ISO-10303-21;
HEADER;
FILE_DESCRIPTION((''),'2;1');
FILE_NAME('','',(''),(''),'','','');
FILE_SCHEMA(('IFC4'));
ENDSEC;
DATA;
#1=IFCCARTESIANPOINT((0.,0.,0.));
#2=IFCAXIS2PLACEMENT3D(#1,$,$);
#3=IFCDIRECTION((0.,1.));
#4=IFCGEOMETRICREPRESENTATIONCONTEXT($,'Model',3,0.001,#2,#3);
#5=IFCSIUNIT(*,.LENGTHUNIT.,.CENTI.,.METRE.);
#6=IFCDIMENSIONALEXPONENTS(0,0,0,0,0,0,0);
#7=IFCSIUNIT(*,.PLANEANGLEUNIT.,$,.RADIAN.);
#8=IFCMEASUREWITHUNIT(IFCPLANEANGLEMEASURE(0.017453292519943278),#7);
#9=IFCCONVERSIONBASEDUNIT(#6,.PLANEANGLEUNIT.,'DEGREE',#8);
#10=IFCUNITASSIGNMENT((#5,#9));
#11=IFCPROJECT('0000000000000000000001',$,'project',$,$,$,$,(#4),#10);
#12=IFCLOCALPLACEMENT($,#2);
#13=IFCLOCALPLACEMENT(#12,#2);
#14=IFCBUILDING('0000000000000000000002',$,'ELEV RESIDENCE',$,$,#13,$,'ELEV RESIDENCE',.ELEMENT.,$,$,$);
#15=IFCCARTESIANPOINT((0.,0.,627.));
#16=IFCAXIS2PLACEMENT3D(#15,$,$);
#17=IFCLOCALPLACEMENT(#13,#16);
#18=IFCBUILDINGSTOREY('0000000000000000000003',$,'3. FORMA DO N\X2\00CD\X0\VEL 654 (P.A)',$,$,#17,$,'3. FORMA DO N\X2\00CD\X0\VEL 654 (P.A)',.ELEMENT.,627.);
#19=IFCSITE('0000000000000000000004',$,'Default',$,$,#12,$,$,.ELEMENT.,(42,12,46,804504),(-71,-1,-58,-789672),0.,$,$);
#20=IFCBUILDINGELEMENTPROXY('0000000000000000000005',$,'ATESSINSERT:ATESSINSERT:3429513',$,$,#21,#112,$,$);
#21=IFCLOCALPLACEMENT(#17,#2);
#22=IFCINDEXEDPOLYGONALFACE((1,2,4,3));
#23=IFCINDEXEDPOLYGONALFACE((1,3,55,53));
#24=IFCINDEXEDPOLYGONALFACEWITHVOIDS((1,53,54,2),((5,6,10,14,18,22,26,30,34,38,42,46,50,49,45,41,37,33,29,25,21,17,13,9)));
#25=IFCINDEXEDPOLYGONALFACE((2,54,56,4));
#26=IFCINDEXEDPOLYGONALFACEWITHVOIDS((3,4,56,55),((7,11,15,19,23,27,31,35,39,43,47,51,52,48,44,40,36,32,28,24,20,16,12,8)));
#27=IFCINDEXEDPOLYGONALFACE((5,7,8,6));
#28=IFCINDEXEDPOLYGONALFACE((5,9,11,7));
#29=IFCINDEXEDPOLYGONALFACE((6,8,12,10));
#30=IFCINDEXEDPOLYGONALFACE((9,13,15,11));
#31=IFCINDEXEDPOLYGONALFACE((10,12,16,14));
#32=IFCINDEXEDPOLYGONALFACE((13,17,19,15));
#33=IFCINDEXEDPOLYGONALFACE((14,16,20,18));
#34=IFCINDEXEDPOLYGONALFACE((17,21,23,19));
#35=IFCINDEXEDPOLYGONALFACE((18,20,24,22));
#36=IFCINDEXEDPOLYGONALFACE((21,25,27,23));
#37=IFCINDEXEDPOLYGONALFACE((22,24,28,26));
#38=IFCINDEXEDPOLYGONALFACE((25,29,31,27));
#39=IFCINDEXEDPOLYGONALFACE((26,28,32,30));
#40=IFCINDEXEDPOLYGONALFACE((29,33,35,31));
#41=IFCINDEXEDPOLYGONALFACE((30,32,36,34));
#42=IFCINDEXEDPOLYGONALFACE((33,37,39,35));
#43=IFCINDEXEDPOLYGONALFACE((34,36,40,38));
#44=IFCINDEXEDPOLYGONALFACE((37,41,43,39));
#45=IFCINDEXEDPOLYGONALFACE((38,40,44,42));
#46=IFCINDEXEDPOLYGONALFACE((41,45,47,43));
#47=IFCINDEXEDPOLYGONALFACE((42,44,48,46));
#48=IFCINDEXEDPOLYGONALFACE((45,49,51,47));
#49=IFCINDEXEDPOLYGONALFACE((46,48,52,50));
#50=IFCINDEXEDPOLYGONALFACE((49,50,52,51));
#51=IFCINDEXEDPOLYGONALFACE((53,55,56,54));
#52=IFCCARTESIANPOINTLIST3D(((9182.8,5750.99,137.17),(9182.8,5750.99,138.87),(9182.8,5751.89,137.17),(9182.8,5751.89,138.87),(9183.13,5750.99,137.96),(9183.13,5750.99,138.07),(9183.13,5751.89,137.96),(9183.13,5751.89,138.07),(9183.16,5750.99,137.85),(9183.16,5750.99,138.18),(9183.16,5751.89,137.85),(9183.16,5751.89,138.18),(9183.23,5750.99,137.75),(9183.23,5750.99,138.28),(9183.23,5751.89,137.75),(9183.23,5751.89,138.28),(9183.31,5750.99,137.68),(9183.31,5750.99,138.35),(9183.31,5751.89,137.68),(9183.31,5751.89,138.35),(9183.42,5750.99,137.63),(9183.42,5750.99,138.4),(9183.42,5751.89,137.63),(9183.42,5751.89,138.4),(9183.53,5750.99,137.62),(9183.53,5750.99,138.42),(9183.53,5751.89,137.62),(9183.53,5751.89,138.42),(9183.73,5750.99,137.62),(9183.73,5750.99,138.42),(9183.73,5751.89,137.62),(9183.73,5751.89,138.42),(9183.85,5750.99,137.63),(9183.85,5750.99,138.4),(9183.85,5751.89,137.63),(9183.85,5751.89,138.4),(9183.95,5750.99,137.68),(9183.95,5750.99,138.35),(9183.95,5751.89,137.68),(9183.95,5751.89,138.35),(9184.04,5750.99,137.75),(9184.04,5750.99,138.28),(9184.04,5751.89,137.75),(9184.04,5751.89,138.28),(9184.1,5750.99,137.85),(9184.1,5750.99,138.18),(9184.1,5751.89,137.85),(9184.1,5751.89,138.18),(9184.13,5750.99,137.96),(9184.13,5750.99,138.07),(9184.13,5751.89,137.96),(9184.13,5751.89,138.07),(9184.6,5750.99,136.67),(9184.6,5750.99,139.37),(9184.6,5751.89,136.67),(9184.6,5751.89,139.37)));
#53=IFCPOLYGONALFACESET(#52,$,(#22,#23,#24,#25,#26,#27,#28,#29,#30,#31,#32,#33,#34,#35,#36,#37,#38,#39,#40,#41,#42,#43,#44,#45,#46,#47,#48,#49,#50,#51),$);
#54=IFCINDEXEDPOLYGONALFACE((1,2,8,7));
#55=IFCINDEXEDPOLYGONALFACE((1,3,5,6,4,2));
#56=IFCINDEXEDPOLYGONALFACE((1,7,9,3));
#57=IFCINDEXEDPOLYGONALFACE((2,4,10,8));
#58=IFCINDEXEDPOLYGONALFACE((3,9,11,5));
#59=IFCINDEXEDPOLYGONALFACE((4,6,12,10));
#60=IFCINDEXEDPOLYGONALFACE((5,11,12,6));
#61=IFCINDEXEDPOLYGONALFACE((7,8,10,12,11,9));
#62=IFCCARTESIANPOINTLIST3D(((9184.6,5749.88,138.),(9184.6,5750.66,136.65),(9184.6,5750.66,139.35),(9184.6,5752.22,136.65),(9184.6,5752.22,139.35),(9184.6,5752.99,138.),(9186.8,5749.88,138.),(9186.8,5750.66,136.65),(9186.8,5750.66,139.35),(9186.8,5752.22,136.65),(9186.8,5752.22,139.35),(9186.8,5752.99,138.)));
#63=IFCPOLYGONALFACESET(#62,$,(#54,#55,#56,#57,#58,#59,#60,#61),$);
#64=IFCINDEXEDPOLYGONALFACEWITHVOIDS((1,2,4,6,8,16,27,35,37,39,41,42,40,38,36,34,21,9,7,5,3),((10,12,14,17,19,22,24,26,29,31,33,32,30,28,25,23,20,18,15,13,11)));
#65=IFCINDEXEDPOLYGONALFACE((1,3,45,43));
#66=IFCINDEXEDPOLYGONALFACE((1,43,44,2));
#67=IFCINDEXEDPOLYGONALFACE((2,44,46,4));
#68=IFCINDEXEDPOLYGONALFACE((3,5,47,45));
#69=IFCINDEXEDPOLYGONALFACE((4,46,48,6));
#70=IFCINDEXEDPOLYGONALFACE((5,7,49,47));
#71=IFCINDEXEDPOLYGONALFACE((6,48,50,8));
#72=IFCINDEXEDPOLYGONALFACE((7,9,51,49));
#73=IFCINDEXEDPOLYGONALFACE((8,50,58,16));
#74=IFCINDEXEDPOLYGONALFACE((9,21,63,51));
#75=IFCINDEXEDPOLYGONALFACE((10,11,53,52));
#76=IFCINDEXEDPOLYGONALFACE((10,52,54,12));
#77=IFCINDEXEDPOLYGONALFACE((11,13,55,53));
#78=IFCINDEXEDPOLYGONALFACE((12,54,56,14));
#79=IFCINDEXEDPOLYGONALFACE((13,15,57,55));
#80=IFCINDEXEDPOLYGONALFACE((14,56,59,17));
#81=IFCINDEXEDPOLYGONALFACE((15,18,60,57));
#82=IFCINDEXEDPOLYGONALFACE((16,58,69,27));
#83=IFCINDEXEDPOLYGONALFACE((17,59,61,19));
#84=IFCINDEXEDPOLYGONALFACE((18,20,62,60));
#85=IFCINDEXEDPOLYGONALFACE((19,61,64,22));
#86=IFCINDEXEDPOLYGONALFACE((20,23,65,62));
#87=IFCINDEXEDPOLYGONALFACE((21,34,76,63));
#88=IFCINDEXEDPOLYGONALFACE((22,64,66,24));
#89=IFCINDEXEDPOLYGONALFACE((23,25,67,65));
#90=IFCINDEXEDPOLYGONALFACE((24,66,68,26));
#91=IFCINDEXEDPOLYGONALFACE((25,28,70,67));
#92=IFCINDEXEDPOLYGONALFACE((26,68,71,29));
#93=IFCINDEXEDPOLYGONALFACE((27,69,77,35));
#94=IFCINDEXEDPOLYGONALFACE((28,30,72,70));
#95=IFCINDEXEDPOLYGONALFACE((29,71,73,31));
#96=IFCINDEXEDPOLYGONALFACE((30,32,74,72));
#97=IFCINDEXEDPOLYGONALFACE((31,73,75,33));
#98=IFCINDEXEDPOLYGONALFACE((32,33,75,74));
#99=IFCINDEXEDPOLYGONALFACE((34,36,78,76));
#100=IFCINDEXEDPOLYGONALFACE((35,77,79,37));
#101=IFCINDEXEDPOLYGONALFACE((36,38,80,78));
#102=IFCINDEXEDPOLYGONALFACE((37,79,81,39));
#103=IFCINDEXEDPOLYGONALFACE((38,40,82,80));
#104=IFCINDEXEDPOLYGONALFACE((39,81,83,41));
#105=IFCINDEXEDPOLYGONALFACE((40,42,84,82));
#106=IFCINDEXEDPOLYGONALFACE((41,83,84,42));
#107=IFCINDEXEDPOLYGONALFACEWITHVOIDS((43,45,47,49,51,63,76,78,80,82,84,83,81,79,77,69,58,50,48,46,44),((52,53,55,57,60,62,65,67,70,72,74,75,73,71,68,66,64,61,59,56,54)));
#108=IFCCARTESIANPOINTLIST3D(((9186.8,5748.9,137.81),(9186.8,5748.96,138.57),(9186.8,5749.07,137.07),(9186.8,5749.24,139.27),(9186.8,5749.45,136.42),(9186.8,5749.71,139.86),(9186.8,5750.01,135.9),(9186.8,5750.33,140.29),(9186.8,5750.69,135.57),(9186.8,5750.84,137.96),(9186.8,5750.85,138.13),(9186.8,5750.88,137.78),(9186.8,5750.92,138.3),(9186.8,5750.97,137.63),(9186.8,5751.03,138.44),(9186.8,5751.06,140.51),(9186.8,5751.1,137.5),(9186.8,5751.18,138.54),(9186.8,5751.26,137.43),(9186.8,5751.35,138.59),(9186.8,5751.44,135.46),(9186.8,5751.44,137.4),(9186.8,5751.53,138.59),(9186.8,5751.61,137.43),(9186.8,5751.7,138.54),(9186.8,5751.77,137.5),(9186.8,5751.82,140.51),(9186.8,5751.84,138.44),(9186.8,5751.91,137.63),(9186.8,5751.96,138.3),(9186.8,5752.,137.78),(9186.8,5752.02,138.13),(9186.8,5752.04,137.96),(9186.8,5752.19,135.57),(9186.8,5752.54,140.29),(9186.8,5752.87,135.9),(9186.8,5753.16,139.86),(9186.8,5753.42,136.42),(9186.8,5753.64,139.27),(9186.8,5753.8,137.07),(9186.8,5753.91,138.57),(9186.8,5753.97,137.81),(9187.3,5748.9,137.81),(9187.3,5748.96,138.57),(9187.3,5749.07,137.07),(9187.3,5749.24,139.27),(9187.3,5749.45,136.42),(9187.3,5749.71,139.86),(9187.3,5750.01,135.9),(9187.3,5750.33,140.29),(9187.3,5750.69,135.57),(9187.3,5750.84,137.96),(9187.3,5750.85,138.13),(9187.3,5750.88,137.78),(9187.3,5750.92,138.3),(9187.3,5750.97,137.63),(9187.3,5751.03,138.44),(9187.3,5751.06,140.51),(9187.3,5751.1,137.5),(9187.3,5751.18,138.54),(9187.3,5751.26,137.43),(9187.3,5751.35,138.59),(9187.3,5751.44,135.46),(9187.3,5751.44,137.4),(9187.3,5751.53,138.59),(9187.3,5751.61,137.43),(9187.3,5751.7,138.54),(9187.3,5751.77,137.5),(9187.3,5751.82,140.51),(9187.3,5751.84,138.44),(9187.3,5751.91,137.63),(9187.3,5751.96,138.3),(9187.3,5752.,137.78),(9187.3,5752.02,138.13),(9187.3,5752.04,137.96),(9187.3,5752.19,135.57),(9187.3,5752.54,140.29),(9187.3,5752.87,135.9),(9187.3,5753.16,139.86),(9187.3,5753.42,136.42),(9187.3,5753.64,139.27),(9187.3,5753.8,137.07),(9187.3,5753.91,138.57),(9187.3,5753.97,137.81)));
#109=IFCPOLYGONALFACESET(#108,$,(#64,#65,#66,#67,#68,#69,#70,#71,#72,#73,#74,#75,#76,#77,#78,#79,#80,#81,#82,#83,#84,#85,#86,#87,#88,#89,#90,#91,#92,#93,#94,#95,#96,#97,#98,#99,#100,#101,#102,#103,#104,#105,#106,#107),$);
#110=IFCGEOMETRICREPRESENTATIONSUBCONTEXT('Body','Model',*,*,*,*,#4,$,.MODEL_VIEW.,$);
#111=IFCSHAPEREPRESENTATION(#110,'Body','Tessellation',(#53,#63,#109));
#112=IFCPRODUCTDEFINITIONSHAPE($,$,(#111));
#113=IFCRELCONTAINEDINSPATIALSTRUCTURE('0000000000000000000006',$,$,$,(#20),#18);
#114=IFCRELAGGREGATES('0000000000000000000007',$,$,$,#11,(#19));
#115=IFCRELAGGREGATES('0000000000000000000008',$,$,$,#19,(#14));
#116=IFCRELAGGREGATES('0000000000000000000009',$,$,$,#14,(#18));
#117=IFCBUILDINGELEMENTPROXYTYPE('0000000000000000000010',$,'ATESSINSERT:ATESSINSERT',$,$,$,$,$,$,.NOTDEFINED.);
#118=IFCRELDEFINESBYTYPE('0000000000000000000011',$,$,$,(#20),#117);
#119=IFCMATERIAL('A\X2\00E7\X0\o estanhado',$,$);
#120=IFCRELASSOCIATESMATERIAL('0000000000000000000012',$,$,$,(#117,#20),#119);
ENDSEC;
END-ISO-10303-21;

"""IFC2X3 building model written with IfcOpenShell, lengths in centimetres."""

from ifc_helpers import new_model, entity, si_unit, converted_unit, direction, frame, frame_2d, origin, place, context, subcontext, project, spatial, polyline, circle_curve, parameter, trimmed, segment, composite_curve, hollow_circle, outline, extrude, source, transform, mapped, material, type_object, type_shapes, element, save


model = new_model("IFC2X3")

# Units and contexts
model_context = context("Model", 3, precision=0.001, world=origin(), true_north=direction((0.0, 1.0)))
body_context = subcontext(model_context, "Body", "Model", "MODEL_VIEW")
ifc_project = project(units=[si_unit("LENGTHUNIT", "METRE", prefix="CENTI"), converted_unit("PLANEANGLEUNIT", "DEGREE", entity("IfcPlaneAngleMeasure", 0.017453292519943278), si_unit("PLANEANGLEUNIT", "RADIAN"), dimensions=[0, 0, 0, 0, 0, 0, 0])], contexts=[model_context])

# Site, building, storey
site_placement = place(None, origin())
site = spatial("IfcSite", under=ifc_project, at=site_placement, Name="Default", CompositionType="ELEMENT", RefLatitude=(42, 12, 46, 804504), RefLongitude=(-71, -1, -58, -789672), RefElevation=0.0)
building_placement = place(site_placement, origin())
building = spatial("IfcBuilding", under=site, at=building_placement, Name="ELEV RESIDENCE", LongName="ELEV RESIDENCE", CompositionType="ELEMENT")
storey_placement = place(building_placement, frame((0.0, 0.0, 627.0)))
storey = spatial("IfcBuildingStorey", under=building, at=storey_placement, Name="3. FORMA DO NÍVEL 654 (P.A)", LongName="3. FORMA DO NÍVEL 654 (P.A)", CompositionType="ELEMENT", Elevation=627.0)

# Building element proxy
ifc_material_1 = material(Name="Aço estanhado")
building_element_proxy_type_1 = type_object("IfcBuildingElementProxyType", Name="ATESSINSERT:ATESSINSERT", PredefinedType="NOTDEFINED", material=ifc_material_1)
shared_shape_1 = source(origin(), body_context, "Body", "SweptSolid", [
    extrude(outline(polyline([(-1.35, -0.9), (1.35, -0.9), (0.85, 0.9), (-0.85, 0.9), (-1.35, -0.9)]), holes=[composite_curve([segment(trimmed(circle_curve(frame_2d((0.0, 0.17), x_axis=(1.0, 0.0)), 0.4), [parameter(0.0)], [parameter(180.0)], True, "PARAMETER"), False, "CONTINUOUS"), segment(polyline([(0.4, 0.17), (0.4, -0.03)]), True, "CONTINUOUS"), segment(trimmed(circle_curve(frame_2d((0.0, -0.03), x_axis=(1.0, 0.0)), 0.4), [parameter(180.0)], [parameter(0.0)], True, "PARAMETER"), False, "CONTINUOUS"), segment(polyline([(-0.4, -0.03), (-0.4, 0.17)]), True, "CONTINUOUS")], self_intersect=False)]), frame((-1.4, -0.45, 30.02), z_axis=(0.0, 1.0, 0.0), x_axis=(0.0, 0.0, 1.0)), (0.0, 0.0, 1.0), 0.9),
    extrude(outline(polyline([(-0.78, -1.35), (0.78, -1.35), (1.56, 0.0), (0.78, 1.35), (-0.78, 1.35), (-1.56, 0.0), (-0.78, -1.35)])), frame((-4.5, 0.0, 30.0), z_axis=(1.0, 0.0, 0.0), x_axis=(0.0, 0.5, 0.866025)), (0.0, 0.0, 1.0), 2.2),
    extrude(hollow_circle(Radius=2.54, WallThickness=1.94, at=frame_2d((0.0, 0.0), x_axis=(1.0, 0.0))), frame((-5.0, 0.0, 30.0), z_axis=(1.0, 0.0, 0.0), x_axis=(0.0, 0.0, -1.0)), (0.0, 0.0, 1.0), 0.5),
])
type_shapes(building_element_proxy_type_1, [shared_shape_1])
for number, where, z_axis, x_axis, name in (
    (1, (9182.3, 5751.44, 108.0), (0.0, 0.0, 1.0), (-1.0, 0.0, 0.0), "ATESSINSERT:ATESSINSERT:3429513"),
):
    element("IfcBuildingElementProxy", number, at=place(storey_placement, frame(where, z_axis=z_axis, x_axis=x_axis)), inside=storey, type_object=building_element_proxy_type_1, material=ifc_material_1, Name=name, context=body_context, shape_type="MappedRepresentation", body=[
        mapped(shared_shape_1, transform((0.0, 0.0, 0.0), scale=1.0)),
    ])

save(model, "model.ifc")
